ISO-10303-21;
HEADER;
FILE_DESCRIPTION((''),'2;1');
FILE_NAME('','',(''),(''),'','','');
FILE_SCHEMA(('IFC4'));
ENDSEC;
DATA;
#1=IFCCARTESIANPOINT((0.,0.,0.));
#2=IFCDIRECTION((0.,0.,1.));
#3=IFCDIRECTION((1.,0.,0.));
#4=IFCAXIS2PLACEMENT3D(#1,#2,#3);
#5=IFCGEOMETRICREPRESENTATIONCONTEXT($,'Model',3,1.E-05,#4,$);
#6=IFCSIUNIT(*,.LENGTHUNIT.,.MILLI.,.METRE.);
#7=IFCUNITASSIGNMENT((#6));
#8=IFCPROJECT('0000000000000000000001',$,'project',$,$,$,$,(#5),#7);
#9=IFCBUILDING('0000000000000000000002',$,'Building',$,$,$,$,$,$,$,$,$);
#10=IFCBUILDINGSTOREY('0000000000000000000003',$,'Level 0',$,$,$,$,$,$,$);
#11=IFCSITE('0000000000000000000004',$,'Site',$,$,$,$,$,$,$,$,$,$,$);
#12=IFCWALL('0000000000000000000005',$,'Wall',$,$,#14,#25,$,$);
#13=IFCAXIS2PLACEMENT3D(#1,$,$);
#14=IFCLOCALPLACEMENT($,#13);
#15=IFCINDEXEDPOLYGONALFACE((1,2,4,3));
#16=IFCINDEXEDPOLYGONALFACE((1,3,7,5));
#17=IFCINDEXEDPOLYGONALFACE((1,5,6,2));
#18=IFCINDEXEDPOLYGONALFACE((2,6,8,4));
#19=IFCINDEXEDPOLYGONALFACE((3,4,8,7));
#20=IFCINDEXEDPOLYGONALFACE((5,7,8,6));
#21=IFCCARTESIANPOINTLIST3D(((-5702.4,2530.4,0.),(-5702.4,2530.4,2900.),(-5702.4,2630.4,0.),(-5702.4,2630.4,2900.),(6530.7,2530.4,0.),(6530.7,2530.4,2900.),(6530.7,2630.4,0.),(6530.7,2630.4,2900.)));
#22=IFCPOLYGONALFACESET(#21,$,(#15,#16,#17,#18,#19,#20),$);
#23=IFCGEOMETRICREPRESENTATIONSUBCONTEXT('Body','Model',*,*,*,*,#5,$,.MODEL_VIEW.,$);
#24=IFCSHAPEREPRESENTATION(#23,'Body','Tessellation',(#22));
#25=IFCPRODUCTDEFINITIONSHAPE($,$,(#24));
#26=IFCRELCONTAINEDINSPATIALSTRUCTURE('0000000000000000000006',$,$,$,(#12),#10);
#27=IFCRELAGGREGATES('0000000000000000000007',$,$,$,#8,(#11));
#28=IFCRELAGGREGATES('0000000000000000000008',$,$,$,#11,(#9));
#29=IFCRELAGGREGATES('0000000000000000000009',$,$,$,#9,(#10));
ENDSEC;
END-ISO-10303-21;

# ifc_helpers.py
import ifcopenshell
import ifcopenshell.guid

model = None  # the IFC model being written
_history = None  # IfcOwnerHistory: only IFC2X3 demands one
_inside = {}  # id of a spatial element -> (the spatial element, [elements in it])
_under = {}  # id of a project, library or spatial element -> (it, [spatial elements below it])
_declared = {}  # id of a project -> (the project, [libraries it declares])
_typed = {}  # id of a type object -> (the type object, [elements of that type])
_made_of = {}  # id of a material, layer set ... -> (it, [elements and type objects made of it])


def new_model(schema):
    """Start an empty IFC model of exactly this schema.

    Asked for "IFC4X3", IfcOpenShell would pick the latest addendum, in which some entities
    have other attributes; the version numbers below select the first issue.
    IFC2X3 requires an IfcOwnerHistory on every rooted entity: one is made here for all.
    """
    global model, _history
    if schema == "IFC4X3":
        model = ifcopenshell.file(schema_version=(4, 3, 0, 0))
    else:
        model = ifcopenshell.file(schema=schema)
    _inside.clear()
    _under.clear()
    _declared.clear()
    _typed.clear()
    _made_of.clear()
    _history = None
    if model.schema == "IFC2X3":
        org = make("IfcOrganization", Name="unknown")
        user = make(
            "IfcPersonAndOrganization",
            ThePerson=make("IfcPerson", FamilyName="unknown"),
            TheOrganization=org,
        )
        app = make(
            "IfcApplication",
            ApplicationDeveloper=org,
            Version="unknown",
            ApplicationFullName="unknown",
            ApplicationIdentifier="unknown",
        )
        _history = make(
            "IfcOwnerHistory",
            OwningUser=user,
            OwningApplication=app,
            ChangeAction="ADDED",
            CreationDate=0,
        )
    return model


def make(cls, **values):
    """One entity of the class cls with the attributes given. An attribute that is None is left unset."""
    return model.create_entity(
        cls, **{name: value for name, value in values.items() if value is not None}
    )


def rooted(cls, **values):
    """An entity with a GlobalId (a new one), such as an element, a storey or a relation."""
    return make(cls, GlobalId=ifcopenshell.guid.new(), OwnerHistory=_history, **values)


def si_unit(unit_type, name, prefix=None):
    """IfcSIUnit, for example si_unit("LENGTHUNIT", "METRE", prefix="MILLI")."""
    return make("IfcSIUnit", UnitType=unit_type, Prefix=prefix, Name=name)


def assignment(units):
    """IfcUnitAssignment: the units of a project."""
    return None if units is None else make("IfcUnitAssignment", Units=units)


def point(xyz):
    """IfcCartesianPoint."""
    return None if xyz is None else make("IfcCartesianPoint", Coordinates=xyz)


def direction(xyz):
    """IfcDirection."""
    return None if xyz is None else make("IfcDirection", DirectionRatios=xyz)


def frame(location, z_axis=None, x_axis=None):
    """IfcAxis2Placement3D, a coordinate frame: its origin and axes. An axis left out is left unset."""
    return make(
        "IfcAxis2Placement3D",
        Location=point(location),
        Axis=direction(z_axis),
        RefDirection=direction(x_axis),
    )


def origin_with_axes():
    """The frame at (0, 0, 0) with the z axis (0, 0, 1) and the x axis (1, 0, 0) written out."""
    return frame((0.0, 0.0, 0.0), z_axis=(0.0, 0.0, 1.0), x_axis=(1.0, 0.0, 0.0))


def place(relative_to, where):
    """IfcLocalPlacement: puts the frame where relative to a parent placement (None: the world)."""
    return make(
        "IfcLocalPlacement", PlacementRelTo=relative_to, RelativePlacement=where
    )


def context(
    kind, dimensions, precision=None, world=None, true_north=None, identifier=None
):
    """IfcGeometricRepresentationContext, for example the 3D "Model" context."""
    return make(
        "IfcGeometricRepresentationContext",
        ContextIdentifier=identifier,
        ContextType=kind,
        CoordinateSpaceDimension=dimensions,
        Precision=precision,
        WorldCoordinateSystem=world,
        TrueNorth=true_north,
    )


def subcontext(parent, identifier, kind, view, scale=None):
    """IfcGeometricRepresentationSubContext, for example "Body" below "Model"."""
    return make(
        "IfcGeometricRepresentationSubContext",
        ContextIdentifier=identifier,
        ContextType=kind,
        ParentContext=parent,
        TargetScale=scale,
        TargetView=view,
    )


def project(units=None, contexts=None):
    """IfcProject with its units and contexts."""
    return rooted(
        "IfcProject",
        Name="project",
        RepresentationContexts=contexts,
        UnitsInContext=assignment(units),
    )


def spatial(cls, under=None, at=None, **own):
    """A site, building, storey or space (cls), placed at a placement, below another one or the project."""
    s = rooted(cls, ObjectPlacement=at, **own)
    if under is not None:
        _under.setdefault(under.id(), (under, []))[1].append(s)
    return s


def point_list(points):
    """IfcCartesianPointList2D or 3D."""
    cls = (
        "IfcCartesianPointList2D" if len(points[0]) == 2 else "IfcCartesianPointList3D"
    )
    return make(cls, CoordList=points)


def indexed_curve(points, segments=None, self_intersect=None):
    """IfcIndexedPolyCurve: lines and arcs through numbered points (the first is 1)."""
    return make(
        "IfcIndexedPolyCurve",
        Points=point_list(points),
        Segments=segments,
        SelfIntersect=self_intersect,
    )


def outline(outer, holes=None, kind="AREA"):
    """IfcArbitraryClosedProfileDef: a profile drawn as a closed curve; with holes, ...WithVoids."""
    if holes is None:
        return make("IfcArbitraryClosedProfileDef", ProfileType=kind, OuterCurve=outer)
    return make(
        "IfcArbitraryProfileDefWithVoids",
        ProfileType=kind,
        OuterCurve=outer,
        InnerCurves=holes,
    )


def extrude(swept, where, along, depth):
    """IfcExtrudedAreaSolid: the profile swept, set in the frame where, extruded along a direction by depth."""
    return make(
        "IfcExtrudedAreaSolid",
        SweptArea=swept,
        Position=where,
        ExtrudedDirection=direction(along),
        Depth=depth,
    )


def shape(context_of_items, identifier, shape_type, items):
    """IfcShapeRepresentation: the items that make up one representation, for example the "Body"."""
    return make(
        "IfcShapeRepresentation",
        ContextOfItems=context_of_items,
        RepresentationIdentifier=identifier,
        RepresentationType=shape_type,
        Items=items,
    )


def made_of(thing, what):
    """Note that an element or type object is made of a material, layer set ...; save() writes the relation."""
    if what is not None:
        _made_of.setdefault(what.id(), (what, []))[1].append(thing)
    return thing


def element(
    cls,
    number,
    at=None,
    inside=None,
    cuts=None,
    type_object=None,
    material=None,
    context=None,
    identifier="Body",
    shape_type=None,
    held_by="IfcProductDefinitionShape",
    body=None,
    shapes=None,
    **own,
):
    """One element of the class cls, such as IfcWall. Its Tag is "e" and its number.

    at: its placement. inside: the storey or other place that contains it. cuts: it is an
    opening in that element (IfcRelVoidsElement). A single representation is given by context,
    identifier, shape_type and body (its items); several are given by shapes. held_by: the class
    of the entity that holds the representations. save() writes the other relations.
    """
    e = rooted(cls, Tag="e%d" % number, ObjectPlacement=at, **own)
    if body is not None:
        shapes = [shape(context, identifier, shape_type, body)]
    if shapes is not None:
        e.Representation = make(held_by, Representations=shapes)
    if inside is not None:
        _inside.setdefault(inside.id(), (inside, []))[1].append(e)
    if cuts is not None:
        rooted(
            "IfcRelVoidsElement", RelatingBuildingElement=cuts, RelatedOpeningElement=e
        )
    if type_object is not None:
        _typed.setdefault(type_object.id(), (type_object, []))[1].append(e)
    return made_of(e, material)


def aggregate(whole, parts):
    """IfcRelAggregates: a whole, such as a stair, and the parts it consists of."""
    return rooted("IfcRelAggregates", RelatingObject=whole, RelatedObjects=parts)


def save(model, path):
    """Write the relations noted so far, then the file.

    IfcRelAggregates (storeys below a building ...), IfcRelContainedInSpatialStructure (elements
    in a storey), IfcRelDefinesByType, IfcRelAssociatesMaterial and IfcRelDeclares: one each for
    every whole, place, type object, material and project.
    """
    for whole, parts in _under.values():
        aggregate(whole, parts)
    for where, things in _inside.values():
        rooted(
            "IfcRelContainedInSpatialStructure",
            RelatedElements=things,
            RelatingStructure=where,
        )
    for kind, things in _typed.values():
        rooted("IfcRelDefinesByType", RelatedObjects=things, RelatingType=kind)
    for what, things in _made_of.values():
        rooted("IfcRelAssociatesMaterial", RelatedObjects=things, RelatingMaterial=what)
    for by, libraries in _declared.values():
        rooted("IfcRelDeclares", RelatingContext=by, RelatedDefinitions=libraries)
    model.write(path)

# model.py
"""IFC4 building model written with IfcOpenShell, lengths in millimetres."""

from ifc_helpers import new_model, si_unit, frame, origin_with_axes, place, context, subcontext, project, spatial, indexed_curve, outline, extrude, element, save


model = new_model("IFC4")

# Units and contexts
model_context = context("Model", 3, precision=1e-05, world=origin_with_axes())
body_context = subcontext(model_context, "Body", "Model", "MODEL_VIEW")
ifc_project = project(units=[si_unit("LENGTHUNIT", "METRE", prefix="MILLI")], contexts=[model_context])

# Site, building, storey
site = spatial("IfcSite", under=ifc_project, Name="Site")
building = spatial("IfcBuilding", under=site, Name="Building")
storey = spatial("IfcBuildingStorey", under=building, Name="Level 0")

# Wall
wall_1_placement = place(None, frame((-5702.4, 2530.4, 0.0), z_axis=(0.0, 0.0, 1.0), x_axis=(1.0, 0.0, 0.0)))
element("IfcWall", 1, at=wall_1_placement, inside=storey, Name="Wall", context=body_context, shape_type="SweptSolid", body=[
    extrude(outline(indexed_curve([(0.0, 0.0), (0.0, 99.9), (12233.1, 99.9), (12233.1, 0.0), (0.0, 0.0)], self_intersect=False)), origin_with_axes(), (0.0, 0.0, 1.0), 2900.0),
])

save(model, "model.ifc")
